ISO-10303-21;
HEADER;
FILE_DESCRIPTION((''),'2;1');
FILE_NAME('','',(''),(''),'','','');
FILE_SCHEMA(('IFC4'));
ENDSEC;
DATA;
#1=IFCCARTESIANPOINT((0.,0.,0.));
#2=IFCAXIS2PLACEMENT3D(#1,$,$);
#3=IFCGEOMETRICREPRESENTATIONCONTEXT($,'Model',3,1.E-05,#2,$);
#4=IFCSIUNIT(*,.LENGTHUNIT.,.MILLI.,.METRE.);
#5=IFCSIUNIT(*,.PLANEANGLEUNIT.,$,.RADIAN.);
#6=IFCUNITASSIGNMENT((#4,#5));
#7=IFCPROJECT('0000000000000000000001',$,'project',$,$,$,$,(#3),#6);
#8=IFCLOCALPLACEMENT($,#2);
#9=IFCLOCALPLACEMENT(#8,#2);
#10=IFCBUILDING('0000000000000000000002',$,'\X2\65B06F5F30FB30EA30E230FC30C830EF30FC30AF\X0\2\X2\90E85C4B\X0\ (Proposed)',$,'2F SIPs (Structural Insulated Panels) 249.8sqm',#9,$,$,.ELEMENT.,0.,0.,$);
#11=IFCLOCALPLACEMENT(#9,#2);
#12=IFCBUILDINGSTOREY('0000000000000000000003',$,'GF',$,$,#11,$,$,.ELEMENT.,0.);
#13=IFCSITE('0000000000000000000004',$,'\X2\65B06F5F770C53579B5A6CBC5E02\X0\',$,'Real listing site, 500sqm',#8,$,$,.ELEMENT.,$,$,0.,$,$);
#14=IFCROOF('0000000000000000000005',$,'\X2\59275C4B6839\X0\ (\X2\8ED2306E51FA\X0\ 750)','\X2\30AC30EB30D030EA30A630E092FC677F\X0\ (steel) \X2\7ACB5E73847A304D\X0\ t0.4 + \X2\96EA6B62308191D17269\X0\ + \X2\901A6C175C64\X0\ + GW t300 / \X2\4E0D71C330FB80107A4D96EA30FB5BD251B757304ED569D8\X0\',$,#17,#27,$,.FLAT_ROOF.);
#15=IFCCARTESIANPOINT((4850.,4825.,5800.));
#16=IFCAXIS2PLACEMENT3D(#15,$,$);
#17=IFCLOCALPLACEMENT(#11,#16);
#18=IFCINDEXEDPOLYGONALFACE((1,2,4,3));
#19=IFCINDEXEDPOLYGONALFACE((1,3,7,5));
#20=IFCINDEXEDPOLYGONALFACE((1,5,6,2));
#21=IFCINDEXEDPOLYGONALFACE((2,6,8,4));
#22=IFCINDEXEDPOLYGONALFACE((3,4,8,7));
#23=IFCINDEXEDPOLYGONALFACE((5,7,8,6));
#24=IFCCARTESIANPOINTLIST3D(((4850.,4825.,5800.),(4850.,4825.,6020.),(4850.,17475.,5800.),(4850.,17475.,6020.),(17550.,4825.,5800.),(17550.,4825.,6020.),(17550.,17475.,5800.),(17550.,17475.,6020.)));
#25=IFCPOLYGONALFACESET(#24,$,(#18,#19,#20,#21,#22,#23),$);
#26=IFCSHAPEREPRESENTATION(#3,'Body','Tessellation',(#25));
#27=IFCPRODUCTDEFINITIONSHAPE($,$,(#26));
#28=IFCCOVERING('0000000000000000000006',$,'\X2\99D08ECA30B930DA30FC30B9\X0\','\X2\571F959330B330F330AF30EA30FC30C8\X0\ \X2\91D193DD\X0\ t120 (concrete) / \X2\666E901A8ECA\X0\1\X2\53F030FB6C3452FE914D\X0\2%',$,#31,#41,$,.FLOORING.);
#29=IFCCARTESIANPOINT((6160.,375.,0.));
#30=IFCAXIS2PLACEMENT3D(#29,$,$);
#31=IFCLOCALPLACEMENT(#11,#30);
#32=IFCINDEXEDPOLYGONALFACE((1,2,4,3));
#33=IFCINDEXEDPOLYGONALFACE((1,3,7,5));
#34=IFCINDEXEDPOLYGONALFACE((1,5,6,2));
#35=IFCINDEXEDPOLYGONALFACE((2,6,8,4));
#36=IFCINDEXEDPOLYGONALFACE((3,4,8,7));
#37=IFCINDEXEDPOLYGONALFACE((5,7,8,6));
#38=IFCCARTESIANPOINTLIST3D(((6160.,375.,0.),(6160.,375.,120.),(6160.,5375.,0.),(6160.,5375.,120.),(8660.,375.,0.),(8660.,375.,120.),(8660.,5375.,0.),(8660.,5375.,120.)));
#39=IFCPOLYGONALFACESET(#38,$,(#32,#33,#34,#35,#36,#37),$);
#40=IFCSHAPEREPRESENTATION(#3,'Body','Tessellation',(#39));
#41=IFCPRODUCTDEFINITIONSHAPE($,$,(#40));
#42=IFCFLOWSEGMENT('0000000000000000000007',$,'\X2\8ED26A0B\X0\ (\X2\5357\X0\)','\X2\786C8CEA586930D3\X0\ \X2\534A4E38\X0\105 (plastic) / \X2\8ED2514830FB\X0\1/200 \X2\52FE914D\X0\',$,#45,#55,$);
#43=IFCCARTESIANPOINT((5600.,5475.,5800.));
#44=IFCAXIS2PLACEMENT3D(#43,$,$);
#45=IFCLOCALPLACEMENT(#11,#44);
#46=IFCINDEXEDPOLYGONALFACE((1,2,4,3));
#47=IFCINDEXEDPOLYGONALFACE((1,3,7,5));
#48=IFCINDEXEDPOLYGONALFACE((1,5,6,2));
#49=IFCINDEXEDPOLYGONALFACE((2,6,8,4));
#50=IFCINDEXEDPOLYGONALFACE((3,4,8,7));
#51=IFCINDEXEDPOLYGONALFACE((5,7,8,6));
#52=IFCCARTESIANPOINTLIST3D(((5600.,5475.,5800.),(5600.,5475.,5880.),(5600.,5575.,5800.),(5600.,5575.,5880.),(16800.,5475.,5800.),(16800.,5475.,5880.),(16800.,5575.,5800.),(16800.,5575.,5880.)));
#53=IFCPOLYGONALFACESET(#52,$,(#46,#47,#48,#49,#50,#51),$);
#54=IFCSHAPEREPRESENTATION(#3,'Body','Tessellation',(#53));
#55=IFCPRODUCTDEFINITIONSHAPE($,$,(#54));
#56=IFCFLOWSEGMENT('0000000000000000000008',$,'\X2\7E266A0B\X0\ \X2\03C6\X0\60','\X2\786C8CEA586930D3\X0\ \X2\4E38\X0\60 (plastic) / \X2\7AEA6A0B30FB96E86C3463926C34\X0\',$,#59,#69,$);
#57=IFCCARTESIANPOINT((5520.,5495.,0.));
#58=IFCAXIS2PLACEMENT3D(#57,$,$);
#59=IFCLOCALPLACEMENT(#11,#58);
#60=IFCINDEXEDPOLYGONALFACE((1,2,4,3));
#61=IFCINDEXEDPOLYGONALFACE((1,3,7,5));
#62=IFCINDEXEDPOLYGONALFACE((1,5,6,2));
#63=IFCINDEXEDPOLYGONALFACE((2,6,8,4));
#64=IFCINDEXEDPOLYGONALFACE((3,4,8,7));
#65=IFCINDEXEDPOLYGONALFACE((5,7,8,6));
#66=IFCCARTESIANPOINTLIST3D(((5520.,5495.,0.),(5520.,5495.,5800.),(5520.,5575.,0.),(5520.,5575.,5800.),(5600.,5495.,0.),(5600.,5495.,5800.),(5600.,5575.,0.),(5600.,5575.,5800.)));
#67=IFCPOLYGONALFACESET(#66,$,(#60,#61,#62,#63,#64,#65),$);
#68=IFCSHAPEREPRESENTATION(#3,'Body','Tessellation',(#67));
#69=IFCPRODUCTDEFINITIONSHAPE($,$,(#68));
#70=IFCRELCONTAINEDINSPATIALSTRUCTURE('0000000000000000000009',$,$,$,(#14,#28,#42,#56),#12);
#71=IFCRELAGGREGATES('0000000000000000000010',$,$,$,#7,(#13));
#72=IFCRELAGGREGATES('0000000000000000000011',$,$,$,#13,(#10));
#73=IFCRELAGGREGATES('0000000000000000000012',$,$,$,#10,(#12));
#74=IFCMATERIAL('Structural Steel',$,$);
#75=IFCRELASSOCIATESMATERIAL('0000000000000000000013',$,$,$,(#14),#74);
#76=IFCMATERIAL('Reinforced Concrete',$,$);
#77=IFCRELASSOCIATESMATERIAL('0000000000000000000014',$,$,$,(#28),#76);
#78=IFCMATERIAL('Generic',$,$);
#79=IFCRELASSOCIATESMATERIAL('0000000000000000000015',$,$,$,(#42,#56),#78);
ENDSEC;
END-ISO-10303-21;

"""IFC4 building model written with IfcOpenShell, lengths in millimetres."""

from ifc_helpers import new_model, si_unit, frame, frame_2d, origin, place, context, project, spatial, rectangle, extrude, material, element, save


model = new_model("IFC4")

# Units and contexts
model_context = context("Model", 3, precision=1e-05, world=origin())
ifc_project = project(units=[si_unit("LENGTHUNIT", "METRE", prefix="MILLI"), si_unit("PLANEANGLEUNIT", "RADIAN")], contexts=[model_context])

# Site, building, storey
site_placement = place(None, origin())
site = spatial("IfcSite", under=ifc_project, at=site_placement, Name="新潟県南魚沼市", ObjectType="Real listing site, 500sqm", CompositionType="ELEMENT", RefElevation=0.0)
building_placement = place(site_placement, origin())
building = spatial("IfcBuilding", under=site, at=building_placement, Name="新潟・リモートワーク2部屋 (Proposed)", ObjectType="2F SIPs (Structural Insulated Panels) 249.8sqm", CompositionType="ELEMENT", ElevationOfRefHeight=0.0, ElevationOfTerrain=0.0)
storey_placement = place(building_placement, origin())
storey = spatial("IfcBuildingStorey", under=building, at=storey_placement, Name="GF", CompositionType="ELEMENT", Elevation=0.0)

# Shared definitions
ifc_material_1 = material(Name="Reinforced Concrete")

# Roof
ifc_material_2 = material(Name="Structural Steel")
roof_placement = place(storey_placement, frame((4850.0, 4825.0, 5800.0)))
element("IfcRoof", 1, at=roof_placement, inside=storey, material=ifc_material_2, Name="大屋根 (軒の出 750)", Description="ガルバリウム鋼板 (steel) 立平葺き t0.4 + 雪止め金物 + 通気層 + GW t300 / 不燃・耐積雪・寒冷地仕様", PredefinedType="FLAT_ROOF", context=model_context, shape_type="SweptSolid", body=[
    extrude(rectangle(XDim=12700.0, YDim=12650.0, at=frame_2d((6350.0, 6325.0))), frame((4850.0, 4825.0, 5800.0)), (0.0, 0.0, 1.0), 220.0),
])

# Covering
covering_placement = place(storey_placement, frame((6160.0, 375.0, 0.0)))
element("IfcCovering", 2, at=covering_placement, inside=storey, material=ifc_material_1, Name="駐車スペース", Description="土間コンクリート 金鏝 t120 (concrete) / 普通車1台・水勾配2%", PredefinedType="FLOORING", context=model_context, shape_type="SweptSolid", body=[
    extrude(rectangle(XDim=2500.0, YDim=5000.0, at=frame_2d((1250.0, 2500.0))), frame((6160.0, 375.0, 0.0)), (0.0, 0.0, 1.0), 120.0),
])

# Flow segments
ifc_material_3 = material(Name="Generic")
flow_segment_1_placement = place(storey_placement, frame((5600.0, 5475.0, 5800.0)))
element("IfcFlowSegment", 3, at=flow_segment_1_placement, inside=storey, material=ifc_material_3, Name="軒樋 (南)", Description="硬質塩ビ 半丸105 (plastic) / 軒先・1/200 勾配", context=model_context, shape_type="SweptSolid", body=[
    extrude(rectangle(XDim=11200.0, YDim=100.0, at=frame_2d((5600.0, 50.0))), frame((5600.0, 5475.0, 5800.0)), (0.0, 0.0, 1.0), 80.0),
])
flow_segment_2_placement = place(storey_placement, frame((5520.0, 5495.0, 0.0)))
element("IfcFlowSegment", 4, at=flow_segment_2_placement, inside=storey, material=ifc_material_3, Name="縦樋 φ60", Description="硬質塩ビ 丸60 (plastic) / 竪樋・雨水排水", context=model_context, shape_type="SweptSolid", body=[
    extrude(rectangle(XDim=80.0, YDim=80.0, at=frame_2d((40.0, 40.0))), frame((5520.0, 5495.0, 0.0)), (0.0, 0.0, 1.0), 5800.0),
])

save(model, "model.ifc")
